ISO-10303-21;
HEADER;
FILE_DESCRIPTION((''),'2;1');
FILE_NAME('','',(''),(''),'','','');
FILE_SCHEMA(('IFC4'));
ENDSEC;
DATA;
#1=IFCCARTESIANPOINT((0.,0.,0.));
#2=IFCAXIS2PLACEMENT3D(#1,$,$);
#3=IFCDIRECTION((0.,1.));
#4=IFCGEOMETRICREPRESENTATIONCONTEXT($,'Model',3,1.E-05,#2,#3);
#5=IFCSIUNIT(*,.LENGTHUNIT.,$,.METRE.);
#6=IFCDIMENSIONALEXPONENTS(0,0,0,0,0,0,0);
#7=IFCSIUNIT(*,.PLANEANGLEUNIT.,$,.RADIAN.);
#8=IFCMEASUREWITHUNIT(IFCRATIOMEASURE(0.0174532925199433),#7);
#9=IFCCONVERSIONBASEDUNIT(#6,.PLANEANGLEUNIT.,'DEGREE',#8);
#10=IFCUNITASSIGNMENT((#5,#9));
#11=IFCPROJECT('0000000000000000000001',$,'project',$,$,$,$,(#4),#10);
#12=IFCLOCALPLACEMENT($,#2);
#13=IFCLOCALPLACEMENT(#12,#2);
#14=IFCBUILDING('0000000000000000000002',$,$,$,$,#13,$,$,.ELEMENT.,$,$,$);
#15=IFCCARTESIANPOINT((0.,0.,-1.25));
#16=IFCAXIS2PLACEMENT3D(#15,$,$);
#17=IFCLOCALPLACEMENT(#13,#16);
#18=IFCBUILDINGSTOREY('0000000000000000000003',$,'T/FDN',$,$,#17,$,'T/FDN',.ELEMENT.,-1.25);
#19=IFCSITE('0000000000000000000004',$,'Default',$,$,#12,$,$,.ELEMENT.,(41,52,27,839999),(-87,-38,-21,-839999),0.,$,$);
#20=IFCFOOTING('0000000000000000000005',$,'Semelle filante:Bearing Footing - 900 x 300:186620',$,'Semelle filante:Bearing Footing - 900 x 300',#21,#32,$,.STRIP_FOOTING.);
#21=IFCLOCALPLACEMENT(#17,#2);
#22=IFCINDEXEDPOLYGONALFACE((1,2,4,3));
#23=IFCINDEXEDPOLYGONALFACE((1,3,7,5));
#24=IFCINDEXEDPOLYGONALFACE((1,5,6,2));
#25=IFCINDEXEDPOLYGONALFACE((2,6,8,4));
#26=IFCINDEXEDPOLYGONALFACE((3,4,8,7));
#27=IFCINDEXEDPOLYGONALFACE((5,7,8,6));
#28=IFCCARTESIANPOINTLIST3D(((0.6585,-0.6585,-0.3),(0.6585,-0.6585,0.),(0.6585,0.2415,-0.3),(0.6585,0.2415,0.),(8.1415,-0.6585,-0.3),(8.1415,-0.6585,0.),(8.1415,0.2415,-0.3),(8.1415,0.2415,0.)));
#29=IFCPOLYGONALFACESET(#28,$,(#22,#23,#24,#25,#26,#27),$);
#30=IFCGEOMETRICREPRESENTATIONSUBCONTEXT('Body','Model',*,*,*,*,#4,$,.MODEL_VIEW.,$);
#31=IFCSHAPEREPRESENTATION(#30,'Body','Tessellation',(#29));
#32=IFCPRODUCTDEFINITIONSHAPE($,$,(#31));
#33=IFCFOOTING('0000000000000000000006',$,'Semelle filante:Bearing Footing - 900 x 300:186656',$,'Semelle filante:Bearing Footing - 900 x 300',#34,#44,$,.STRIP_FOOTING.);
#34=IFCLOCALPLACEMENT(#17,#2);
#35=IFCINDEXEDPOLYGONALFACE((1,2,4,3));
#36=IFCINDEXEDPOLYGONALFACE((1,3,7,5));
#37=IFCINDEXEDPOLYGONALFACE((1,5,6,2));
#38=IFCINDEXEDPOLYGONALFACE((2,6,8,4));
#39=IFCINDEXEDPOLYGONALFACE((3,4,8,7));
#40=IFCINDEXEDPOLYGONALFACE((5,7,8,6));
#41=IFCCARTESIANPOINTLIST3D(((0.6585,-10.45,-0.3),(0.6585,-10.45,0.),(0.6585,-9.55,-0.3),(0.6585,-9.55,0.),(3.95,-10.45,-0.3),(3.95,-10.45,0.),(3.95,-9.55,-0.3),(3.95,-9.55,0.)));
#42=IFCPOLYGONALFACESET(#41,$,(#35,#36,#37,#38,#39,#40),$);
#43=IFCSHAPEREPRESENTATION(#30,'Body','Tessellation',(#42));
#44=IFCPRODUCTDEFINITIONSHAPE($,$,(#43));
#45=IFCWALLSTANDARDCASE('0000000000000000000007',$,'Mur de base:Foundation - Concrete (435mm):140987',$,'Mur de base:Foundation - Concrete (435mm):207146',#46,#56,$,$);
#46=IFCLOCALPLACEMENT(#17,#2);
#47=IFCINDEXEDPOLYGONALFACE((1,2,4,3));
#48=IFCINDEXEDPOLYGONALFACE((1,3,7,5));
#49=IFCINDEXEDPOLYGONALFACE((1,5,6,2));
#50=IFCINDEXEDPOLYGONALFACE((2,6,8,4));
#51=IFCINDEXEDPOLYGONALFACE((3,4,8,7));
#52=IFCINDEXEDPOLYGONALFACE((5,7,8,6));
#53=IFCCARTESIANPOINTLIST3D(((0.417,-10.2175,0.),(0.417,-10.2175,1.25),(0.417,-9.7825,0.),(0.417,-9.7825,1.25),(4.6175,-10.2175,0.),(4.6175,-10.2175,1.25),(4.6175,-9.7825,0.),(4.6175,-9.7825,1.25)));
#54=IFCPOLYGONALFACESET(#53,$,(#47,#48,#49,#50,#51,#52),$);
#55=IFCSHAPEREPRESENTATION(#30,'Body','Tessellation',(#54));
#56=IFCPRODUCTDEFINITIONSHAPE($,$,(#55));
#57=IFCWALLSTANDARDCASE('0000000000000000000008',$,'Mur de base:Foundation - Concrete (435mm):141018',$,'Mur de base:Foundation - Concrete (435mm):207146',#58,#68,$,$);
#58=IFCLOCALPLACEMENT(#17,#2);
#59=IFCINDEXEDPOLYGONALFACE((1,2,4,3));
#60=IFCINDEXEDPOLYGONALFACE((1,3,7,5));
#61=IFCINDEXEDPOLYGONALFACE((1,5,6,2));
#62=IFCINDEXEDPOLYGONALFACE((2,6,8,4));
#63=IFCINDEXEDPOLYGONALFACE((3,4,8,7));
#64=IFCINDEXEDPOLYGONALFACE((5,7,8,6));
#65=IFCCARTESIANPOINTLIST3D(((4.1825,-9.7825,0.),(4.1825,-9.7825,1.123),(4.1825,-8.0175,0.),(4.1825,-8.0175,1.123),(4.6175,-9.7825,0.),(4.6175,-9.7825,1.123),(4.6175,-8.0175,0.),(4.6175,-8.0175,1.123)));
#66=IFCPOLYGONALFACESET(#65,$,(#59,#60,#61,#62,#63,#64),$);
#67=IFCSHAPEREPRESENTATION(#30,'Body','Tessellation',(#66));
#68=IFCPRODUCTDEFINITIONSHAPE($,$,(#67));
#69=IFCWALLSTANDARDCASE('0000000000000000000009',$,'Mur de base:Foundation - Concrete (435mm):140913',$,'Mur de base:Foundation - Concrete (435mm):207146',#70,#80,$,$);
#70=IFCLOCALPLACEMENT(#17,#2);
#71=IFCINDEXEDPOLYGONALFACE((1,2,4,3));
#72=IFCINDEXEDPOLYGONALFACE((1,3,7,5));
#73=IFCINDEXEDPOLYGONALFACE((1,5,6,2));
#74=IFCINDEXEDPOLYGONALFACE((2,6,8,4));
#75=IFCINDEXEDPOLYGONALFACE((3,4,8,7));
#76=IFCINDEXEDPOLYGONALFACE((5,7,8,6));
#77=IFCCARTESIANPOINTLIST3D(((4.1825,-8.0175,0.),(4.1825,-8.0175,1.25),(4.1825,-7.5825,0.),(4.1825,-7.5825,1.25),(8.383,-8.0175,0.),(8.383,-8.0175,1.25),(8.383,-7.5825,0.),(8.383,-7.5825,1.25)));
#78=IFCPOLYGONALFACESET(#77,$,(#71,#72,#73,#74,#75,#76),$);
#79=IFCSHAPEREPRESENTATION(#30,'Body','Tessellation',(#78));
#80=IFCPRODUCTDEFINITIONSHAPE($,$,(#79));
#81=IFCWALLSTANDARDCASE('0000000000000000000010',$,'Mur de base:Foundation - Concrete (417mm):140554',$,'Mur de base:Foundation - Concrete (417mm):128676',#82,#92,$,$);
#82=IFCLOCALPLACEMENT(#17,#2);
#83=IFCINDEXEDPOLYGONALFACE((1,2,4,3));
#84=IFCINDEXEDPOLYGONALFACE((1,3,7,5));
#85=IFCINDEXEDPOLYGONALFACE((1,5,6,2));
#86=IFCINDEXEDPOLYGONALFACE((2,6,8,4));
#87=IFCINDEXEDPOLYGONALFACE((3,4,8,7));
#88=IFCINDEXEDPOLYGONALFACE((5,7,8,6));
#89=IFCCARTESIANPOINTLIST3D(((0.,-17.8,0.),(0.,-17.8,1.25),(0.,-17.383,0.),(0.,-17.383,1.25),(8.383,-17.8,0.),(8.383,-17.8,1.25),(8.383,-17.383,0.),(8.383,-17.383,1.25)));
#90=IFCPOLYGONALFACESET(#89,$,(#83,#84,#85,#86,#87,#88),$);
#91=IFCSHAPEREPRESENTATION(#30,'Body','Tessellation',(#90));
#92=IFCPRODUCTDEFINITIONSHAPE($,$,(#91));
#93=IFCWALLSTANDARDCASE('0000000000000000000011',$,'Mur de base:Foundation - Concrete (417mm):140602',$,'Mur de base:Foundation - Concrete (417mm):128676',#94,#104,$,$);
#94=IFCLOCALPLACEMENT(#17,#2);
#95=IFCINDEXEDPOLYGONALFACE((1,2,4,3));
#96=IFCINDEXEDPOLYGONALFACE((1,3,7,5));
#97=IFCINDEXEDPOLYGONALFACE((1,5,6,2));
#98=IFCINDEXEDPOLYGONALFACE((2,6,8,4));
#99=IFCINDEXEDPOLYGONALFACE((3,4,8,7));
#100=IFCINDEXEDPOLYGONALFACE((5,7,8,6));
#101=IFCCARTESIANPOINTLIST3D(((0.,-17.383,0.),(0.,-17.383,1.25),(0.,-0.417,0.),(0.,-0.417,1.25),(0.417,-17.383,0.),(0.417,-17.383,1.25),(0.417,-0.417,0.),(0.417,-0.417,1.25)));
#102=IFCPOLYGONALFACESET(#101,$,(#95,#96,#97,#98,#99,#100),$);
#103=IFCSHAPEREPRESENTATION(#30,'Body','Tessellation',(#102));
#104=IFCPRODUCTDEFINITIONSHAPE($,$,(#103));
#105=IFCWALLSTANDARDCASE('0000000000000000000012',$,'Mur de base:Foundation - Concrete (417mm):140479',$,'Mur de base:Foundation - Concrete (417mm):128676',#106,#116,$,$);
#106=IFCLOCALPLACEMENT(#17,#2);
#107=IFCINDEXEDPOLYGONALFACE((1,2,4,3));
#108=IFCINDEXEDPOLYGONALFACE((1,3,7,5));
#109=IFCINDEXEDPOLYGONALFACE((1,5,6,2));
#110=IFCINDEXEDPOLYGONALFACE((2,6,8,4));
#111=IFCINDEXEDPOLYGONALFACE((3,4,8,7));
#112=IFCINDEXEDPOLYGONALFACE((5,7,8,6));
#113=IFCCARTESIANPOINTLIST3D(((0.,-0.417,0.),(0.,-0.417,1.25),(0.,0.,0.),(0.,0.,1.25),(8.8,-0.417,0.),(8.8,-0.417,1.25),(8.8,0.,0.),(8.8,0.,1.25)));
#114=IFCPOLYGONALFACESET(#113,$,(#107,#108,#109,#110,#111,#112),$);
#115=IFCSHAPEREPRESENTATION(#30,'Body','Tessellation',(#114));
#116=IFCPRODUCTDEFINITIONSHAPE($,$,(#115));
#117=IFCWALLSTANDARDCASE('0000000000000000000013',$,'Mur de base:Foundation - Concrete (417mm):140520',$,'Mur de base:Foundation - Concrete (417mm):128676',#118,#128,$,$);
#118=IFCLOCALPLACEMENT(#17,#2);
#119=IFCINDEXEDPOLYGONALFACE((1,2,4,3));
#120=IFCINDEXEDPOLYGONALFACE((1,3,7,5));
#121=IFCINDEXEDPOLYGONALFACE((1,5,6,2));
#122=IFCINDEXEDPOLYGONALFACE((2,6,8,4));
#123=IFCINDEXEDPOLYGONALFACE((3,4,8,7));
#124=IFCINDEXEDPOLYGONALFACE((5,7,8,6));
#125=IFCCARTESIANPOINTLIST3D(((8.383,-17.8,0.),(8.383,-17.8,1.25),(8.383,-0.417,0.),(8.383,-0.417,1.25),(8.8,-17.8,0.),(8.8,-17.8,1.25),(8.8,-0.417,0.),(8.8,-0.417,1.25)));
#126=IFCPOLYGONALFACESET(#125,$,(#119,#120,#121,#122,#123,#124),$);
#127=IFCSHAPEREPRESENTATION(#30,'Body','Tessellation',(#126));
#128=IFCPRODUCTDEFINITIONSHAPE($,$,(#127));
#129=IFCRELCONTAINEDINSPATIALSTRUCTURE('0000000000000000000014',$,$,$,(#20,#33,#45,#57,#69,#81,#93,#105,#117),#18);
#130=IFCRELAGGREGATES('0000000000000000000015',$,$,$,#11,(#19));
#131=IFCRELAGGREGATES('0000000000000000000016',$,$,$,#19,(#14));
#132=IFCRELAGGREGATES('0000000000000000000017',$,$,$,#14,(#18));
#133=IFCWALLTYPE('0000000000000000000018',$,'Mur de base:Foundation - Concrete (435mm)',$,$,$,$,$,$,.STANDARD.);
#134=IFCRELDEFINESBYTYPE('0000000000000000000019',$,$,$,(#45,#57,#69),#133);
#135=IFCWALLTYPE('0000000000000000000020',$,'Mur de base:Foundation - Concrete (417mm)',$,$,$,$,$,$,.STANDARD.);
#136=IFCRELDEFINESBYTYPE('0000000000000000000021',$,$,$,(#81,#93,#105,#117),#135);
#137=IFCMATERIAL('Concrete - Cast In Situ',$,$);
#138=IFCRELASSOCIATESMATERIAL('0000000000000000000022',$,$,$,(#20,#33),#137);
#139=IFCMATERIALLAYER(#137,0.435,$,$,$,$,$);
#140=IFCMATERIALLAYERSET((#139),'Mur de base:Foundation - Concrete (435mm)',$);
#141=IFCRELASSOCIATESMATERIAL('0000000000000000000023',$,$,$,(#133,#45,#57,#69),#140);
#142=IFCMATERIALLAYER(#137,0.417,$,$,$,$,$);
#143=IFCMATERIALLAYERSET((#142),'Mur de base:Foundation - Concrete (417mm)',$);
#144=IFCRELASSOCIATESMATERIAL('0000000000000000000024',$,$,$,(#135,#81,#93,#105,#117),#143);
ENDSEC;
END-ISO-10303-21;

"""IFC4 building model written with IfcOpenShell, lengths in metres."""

from ifc_helpers import new_model, entity, si_unit, converted_unit, direction, frame, frame_2d, origin, place, context, subcontext, project, spatial, rectangle, extrude, material, layer, layer_set, layer_usage, type_object, element, save


model = new_model("IFC4")

# Units and contexts
model_context = context("Model", 3, precision=1e-05, world=origin(), true_north=direction((0.0, 1.0)))
body_context = subcontext(model_context, "Body", "Model", "MODEL_VIEW")
ifc_project = project(units=[si_unit("LENGTHUNIT", "METRE"), converted_unit("PLANEANGLEUNIT", "DEGREE", entity("IfcRatioMeasure", 0.0174532925199433), si_unit("PLANEANGLEUNIT", "RADIAN"), dimensions=[0, 0, 0, 0, 0, 0, 0])], contexts=[model_context])

# Site, building, storey
site_placement = place(None, origin())
site = spatial("IfcSite", under=ifc_project, at=site_placement, Name="Default", CompositionType="ELEMENT", RefLatitude=(41, 52, 27, 839999), RefLongitude=(-87, -38, -21, -839999), RefElevation=0.0)
building_placement = place(site_placement, origin())
building = spatial("IfcBuilding", under=site, at=building_placement, CompositionType="ELEMENT")
storey_placement = place(building_placement, frame((0.0, 0.0, -1.25)))
storey = spatial("IfcBuildingStorey", under=building, at=storey_placement, Name="T/FDN", LongName="T/FDN", CompositionType="ELEMENT", Elevation=-1.25)

# Footings
ifc_material = material(Name="Concrete - Cast In Situ")
footing_1_placement = place(storey_placement, origin())
element("IfcFooting", 1, at=footing_1_placement, inside=storey, material=ifc_material, Name="Semelle filante:Bearing Footing - 900 x 300:186620", ObjectType="Semelle filante:Bearing Footing - 900 x 300", PredefinedType="STRIP_FOOTING", context=body_context, shape_type="SweptSolid", body=[
    extrude(rectangle(XDim=7.483, YDim=0.9, at=frame_2d((0.0, 0.0), x_axis=(1.0, 0.0))), frame((4.4, -0.2085, -0.3), z_axis=(0.0, 0.0, 1.0), x_axis=(-1.0, 0.0, 0.0)), (0.0, 0.0, 1.0), 0.3),
])
footing_2_placement = place(storey_placement, origin())
element("IfcFooting", 2, at=footing_2_placement, inside=storey, material=ifc_material, Name="Semelle filante:Bearing Footing - 900 x 300:186656", ObjectType="Semelle filante:Bearing Footing - 900 x 300", PredefinedType="STRIP_FOOTING", context=body_context, shape_type="SweptSolid", body=[
    extrude(rectangle(XDim=3.2915, YDim=0.9, at=frame_2d((0.0, 0.0), x_axis=(1.0, 0.0))), frame((2.3043, -10.0, -0.3)), (0.0, 0.0, 1.0), 0.3),
])

# Walls
ifc_layer_1 = layer(ifc_material, 0.435)
ifc_layer_set_1 = layer_set([ifc_layer_1], Name="Mur de base:Foundation - Concrete (435mm)")
ifc_layer_usage_1 = layer_usage(ifc_layer_set_1, "AXIS2", "NEGATIVE", 0.2175)
wall_type_1 = type_object("IfcWallType", Name="Mur de base:Foundation - Concrete (435mm)", PredefinedType="STANDARD", material=ifc_layer_set_1)
wall_1_placement = place(storey_placement, frame((0.417, -10.0, 0.0)))
element("IfcWallStandardCase", 3, at=wall_1_placement, inside=storey, type_object=wall_type_1, material=ifc_layer_usage_1, Name="Mur de base:Foundation - Concrete (435mm):140987", ObjectType="Mur de base:Foundation - Concrete (435mm):207146", context=body_context, shape_type="SweptSolid", body=[
    extrude(rectangle(XDim=4.2005, YDim=0.435, at=frame_2d((2.1002, 0.0), x_axis=(-1.0, 0.0))), origin(), (0.0, 0.0, 1.0), 1.25),
])
ifc_layer_usage_2 = layer_usage(ifc_layer_set_1, "AXIS2", "NEGATIVE", 0.2175)
wall_2_placement = place(storey_placement, frame((4.4, -9.7825, 0.0), z_axis=(0.0, 0.0, 1.0), x_axis=(0.0, 1.0, 0.0)))
element("IfcWallStandardCase", 4, at=wall_2_placement, inside=storey, type_object=wall_type_1, material=ifc_layer_usage_2, Name="Mur de base:Foundation - Concrete (435mm):141018", ObjectType="Mur de base:Foundation - Concrete (435mm):207146", context=body_context, shape_type="SweptSolid", body=[
    extrude(rectangle(XDim=1.765, YDim=0.435, at=frame_2d((0.8825, 0.0), x_axis=(-1.0, 0.0))), origin(), (0.0, 0.0, 1.0), 1.123),
])
ifc_layer_usage_3 = layer_usage(ifc_layer_set_1, "AXIS2", "NEGATIVE", 0.2175)
wall_3_placement = place(storey_placement, frame((8.383, -7.8, 0.0), z_axis=(0.0, 0.0, 1.0), x_axis=(-1.0, 0.0, 0.0)))
element("IfcWallStandardCase", 5, at=wall_3_placement, inside=storey, type_object=wall_type_1, material=ifc_layer_usage_3, Name="Mur de base:Foundation - Concrete (435mm):140913", ObjectType="Mur de base:Foundation - Concrete (435mm):207146", context=body_context, shape_type="SweptSolid", body=[
    extrude(rectangle(XDim=4.2005, YDim=0.435, at=frame_2d((2.1002, 0.0), x_axis=(-1.0, 0.0))), origin(), (0.0, 0.0, 1.0), 1.25),
])
ifc_layer_2 = layer(ifc_material, 0.417)
ifc_layer_set_2 = layer_set([ifc_layer_2], Name="Mur de base:Foundation - Concrete (417mm)")
ifc_layer_usage_4 = layer_usage(ifc_layer_set_2, "AXIS2", "NEGATIVE", 0.2085)
wall_type_2 = type_object("IfcWallType", Name="Mur de base:Foundation - Concrete (417mm)", PredefinedType="STANDARD", material=ifc_layer_set_2)
wall_4_placement = place(storey_placement, frame((8.383, -17.5915, 0.0), z_axis=(0.0, 0.0, 1.0), x_axis=(-1.0, 0.0, 0.0)))
element("IfcWallStandardCase", 6, at=wall_4_placement, inside=storey, type_object=wall_type_2, material=ifc_layer_usage_4, Name="Mur de base:Foundation - Concrete (417mm):140554", ObjectType="Mur de base:Foundation - Concrete (417mm):128676", context=body_context, shape_type="SweptSolid", body=[
    extrude(rectangle(XDim=8.383, YDim=0.417, at=frame_2d((4.1915, 0.0), x_axis=(-1.0, 0.0))), origin(), (0.0, 0.0, 1.0), 1.25),
])
ifc_layer_usage_5 = layer_usage(ifc_layer_set_2, "AXIS2", "NEGATIVE", 0.2085)
wall_5_placement = place(storey_placement, frame((0.2085, -17.383, 0.0), z_axis=(0.0, 0.0, 1.0), x_axis=(0.0, 1.0, 0.0)))
element("IfcWallStandardCase", 7, at=wall_5_placement, inside=storey, type_object=wall_type_2, material=ifc_layer_usage_5, Name="Mur de base:Foundation - Concrete (417mm):140602", ObjectType="Mur de base:Foundation - Concrete (417mm):128676", context=body_context, shape_type="SweptSolid", body=[
    extrude(rectangle(XDim=16.966, YDim=0.417, at=frame_2d((8.483, 0.0), x_axis=(-1.0, 0.0))), origin(), (0.0, 0.0, 1.0), 1.25),
])
ifc_layer_usage_6 = layer_usage(ifc_layer_set_2, "AXIS2", "NEGATIVE", 0.2085)
wall_6_placement = place(storey_placement, frame((0.0, -0.2085, 0.0)))
element("IfcWallStandardCase", 8, at=wall_6_placement, inside=storey, type_object=wall_type_2, material=ifc_layer_usage_6, Name="Mur de base:Foundation - Concrete (417mm):140479", ObjectType="Mur de base:Foundation - Concrete (417mm):128676", context=body_context, shape_type="SweptSolid", body=[
    extrude(rectangle(XDim=8.8, YDim=0.417, at=frame_2d((4.4, 0.0), x_axis=(-1.0, 0.0))), origin(), (0.0, 0.0, 1.0), 1.25),
])
ifc_layer_usage_7 = layer_usage(ifc_layer_set_2, "AXIS2", "NEGATIVE", 0.2085)
wall_7_placement = place(storey_placement, frame((8.5915, -0.417, 0.0), z_axis=(0.0, 0.0, 1.0), x_axis=(0.0, -1.0, 0.0)))
element("IfcWallStandardCase", 9, at=wall_7_placement, inside=storey, type_object=wall_type_2, material=ifc_layer_usage_7, Name="Mur de base:Foundation - Concrete (417mm):140520", ObjectType="Mur de base:Foundation - Concrete (417mm):128676", context=body_context, shape_type="SweptSolid", body=[
    extrude(rectangle(XDim=17.383, YDim=0.417, at=frame_2d((8.6915, 0.0), x_axis=(-1.0, 0.0))), origin(), (0.0, 0.0, 1.0), 1.25),
])

save(model, "model.ifc")
